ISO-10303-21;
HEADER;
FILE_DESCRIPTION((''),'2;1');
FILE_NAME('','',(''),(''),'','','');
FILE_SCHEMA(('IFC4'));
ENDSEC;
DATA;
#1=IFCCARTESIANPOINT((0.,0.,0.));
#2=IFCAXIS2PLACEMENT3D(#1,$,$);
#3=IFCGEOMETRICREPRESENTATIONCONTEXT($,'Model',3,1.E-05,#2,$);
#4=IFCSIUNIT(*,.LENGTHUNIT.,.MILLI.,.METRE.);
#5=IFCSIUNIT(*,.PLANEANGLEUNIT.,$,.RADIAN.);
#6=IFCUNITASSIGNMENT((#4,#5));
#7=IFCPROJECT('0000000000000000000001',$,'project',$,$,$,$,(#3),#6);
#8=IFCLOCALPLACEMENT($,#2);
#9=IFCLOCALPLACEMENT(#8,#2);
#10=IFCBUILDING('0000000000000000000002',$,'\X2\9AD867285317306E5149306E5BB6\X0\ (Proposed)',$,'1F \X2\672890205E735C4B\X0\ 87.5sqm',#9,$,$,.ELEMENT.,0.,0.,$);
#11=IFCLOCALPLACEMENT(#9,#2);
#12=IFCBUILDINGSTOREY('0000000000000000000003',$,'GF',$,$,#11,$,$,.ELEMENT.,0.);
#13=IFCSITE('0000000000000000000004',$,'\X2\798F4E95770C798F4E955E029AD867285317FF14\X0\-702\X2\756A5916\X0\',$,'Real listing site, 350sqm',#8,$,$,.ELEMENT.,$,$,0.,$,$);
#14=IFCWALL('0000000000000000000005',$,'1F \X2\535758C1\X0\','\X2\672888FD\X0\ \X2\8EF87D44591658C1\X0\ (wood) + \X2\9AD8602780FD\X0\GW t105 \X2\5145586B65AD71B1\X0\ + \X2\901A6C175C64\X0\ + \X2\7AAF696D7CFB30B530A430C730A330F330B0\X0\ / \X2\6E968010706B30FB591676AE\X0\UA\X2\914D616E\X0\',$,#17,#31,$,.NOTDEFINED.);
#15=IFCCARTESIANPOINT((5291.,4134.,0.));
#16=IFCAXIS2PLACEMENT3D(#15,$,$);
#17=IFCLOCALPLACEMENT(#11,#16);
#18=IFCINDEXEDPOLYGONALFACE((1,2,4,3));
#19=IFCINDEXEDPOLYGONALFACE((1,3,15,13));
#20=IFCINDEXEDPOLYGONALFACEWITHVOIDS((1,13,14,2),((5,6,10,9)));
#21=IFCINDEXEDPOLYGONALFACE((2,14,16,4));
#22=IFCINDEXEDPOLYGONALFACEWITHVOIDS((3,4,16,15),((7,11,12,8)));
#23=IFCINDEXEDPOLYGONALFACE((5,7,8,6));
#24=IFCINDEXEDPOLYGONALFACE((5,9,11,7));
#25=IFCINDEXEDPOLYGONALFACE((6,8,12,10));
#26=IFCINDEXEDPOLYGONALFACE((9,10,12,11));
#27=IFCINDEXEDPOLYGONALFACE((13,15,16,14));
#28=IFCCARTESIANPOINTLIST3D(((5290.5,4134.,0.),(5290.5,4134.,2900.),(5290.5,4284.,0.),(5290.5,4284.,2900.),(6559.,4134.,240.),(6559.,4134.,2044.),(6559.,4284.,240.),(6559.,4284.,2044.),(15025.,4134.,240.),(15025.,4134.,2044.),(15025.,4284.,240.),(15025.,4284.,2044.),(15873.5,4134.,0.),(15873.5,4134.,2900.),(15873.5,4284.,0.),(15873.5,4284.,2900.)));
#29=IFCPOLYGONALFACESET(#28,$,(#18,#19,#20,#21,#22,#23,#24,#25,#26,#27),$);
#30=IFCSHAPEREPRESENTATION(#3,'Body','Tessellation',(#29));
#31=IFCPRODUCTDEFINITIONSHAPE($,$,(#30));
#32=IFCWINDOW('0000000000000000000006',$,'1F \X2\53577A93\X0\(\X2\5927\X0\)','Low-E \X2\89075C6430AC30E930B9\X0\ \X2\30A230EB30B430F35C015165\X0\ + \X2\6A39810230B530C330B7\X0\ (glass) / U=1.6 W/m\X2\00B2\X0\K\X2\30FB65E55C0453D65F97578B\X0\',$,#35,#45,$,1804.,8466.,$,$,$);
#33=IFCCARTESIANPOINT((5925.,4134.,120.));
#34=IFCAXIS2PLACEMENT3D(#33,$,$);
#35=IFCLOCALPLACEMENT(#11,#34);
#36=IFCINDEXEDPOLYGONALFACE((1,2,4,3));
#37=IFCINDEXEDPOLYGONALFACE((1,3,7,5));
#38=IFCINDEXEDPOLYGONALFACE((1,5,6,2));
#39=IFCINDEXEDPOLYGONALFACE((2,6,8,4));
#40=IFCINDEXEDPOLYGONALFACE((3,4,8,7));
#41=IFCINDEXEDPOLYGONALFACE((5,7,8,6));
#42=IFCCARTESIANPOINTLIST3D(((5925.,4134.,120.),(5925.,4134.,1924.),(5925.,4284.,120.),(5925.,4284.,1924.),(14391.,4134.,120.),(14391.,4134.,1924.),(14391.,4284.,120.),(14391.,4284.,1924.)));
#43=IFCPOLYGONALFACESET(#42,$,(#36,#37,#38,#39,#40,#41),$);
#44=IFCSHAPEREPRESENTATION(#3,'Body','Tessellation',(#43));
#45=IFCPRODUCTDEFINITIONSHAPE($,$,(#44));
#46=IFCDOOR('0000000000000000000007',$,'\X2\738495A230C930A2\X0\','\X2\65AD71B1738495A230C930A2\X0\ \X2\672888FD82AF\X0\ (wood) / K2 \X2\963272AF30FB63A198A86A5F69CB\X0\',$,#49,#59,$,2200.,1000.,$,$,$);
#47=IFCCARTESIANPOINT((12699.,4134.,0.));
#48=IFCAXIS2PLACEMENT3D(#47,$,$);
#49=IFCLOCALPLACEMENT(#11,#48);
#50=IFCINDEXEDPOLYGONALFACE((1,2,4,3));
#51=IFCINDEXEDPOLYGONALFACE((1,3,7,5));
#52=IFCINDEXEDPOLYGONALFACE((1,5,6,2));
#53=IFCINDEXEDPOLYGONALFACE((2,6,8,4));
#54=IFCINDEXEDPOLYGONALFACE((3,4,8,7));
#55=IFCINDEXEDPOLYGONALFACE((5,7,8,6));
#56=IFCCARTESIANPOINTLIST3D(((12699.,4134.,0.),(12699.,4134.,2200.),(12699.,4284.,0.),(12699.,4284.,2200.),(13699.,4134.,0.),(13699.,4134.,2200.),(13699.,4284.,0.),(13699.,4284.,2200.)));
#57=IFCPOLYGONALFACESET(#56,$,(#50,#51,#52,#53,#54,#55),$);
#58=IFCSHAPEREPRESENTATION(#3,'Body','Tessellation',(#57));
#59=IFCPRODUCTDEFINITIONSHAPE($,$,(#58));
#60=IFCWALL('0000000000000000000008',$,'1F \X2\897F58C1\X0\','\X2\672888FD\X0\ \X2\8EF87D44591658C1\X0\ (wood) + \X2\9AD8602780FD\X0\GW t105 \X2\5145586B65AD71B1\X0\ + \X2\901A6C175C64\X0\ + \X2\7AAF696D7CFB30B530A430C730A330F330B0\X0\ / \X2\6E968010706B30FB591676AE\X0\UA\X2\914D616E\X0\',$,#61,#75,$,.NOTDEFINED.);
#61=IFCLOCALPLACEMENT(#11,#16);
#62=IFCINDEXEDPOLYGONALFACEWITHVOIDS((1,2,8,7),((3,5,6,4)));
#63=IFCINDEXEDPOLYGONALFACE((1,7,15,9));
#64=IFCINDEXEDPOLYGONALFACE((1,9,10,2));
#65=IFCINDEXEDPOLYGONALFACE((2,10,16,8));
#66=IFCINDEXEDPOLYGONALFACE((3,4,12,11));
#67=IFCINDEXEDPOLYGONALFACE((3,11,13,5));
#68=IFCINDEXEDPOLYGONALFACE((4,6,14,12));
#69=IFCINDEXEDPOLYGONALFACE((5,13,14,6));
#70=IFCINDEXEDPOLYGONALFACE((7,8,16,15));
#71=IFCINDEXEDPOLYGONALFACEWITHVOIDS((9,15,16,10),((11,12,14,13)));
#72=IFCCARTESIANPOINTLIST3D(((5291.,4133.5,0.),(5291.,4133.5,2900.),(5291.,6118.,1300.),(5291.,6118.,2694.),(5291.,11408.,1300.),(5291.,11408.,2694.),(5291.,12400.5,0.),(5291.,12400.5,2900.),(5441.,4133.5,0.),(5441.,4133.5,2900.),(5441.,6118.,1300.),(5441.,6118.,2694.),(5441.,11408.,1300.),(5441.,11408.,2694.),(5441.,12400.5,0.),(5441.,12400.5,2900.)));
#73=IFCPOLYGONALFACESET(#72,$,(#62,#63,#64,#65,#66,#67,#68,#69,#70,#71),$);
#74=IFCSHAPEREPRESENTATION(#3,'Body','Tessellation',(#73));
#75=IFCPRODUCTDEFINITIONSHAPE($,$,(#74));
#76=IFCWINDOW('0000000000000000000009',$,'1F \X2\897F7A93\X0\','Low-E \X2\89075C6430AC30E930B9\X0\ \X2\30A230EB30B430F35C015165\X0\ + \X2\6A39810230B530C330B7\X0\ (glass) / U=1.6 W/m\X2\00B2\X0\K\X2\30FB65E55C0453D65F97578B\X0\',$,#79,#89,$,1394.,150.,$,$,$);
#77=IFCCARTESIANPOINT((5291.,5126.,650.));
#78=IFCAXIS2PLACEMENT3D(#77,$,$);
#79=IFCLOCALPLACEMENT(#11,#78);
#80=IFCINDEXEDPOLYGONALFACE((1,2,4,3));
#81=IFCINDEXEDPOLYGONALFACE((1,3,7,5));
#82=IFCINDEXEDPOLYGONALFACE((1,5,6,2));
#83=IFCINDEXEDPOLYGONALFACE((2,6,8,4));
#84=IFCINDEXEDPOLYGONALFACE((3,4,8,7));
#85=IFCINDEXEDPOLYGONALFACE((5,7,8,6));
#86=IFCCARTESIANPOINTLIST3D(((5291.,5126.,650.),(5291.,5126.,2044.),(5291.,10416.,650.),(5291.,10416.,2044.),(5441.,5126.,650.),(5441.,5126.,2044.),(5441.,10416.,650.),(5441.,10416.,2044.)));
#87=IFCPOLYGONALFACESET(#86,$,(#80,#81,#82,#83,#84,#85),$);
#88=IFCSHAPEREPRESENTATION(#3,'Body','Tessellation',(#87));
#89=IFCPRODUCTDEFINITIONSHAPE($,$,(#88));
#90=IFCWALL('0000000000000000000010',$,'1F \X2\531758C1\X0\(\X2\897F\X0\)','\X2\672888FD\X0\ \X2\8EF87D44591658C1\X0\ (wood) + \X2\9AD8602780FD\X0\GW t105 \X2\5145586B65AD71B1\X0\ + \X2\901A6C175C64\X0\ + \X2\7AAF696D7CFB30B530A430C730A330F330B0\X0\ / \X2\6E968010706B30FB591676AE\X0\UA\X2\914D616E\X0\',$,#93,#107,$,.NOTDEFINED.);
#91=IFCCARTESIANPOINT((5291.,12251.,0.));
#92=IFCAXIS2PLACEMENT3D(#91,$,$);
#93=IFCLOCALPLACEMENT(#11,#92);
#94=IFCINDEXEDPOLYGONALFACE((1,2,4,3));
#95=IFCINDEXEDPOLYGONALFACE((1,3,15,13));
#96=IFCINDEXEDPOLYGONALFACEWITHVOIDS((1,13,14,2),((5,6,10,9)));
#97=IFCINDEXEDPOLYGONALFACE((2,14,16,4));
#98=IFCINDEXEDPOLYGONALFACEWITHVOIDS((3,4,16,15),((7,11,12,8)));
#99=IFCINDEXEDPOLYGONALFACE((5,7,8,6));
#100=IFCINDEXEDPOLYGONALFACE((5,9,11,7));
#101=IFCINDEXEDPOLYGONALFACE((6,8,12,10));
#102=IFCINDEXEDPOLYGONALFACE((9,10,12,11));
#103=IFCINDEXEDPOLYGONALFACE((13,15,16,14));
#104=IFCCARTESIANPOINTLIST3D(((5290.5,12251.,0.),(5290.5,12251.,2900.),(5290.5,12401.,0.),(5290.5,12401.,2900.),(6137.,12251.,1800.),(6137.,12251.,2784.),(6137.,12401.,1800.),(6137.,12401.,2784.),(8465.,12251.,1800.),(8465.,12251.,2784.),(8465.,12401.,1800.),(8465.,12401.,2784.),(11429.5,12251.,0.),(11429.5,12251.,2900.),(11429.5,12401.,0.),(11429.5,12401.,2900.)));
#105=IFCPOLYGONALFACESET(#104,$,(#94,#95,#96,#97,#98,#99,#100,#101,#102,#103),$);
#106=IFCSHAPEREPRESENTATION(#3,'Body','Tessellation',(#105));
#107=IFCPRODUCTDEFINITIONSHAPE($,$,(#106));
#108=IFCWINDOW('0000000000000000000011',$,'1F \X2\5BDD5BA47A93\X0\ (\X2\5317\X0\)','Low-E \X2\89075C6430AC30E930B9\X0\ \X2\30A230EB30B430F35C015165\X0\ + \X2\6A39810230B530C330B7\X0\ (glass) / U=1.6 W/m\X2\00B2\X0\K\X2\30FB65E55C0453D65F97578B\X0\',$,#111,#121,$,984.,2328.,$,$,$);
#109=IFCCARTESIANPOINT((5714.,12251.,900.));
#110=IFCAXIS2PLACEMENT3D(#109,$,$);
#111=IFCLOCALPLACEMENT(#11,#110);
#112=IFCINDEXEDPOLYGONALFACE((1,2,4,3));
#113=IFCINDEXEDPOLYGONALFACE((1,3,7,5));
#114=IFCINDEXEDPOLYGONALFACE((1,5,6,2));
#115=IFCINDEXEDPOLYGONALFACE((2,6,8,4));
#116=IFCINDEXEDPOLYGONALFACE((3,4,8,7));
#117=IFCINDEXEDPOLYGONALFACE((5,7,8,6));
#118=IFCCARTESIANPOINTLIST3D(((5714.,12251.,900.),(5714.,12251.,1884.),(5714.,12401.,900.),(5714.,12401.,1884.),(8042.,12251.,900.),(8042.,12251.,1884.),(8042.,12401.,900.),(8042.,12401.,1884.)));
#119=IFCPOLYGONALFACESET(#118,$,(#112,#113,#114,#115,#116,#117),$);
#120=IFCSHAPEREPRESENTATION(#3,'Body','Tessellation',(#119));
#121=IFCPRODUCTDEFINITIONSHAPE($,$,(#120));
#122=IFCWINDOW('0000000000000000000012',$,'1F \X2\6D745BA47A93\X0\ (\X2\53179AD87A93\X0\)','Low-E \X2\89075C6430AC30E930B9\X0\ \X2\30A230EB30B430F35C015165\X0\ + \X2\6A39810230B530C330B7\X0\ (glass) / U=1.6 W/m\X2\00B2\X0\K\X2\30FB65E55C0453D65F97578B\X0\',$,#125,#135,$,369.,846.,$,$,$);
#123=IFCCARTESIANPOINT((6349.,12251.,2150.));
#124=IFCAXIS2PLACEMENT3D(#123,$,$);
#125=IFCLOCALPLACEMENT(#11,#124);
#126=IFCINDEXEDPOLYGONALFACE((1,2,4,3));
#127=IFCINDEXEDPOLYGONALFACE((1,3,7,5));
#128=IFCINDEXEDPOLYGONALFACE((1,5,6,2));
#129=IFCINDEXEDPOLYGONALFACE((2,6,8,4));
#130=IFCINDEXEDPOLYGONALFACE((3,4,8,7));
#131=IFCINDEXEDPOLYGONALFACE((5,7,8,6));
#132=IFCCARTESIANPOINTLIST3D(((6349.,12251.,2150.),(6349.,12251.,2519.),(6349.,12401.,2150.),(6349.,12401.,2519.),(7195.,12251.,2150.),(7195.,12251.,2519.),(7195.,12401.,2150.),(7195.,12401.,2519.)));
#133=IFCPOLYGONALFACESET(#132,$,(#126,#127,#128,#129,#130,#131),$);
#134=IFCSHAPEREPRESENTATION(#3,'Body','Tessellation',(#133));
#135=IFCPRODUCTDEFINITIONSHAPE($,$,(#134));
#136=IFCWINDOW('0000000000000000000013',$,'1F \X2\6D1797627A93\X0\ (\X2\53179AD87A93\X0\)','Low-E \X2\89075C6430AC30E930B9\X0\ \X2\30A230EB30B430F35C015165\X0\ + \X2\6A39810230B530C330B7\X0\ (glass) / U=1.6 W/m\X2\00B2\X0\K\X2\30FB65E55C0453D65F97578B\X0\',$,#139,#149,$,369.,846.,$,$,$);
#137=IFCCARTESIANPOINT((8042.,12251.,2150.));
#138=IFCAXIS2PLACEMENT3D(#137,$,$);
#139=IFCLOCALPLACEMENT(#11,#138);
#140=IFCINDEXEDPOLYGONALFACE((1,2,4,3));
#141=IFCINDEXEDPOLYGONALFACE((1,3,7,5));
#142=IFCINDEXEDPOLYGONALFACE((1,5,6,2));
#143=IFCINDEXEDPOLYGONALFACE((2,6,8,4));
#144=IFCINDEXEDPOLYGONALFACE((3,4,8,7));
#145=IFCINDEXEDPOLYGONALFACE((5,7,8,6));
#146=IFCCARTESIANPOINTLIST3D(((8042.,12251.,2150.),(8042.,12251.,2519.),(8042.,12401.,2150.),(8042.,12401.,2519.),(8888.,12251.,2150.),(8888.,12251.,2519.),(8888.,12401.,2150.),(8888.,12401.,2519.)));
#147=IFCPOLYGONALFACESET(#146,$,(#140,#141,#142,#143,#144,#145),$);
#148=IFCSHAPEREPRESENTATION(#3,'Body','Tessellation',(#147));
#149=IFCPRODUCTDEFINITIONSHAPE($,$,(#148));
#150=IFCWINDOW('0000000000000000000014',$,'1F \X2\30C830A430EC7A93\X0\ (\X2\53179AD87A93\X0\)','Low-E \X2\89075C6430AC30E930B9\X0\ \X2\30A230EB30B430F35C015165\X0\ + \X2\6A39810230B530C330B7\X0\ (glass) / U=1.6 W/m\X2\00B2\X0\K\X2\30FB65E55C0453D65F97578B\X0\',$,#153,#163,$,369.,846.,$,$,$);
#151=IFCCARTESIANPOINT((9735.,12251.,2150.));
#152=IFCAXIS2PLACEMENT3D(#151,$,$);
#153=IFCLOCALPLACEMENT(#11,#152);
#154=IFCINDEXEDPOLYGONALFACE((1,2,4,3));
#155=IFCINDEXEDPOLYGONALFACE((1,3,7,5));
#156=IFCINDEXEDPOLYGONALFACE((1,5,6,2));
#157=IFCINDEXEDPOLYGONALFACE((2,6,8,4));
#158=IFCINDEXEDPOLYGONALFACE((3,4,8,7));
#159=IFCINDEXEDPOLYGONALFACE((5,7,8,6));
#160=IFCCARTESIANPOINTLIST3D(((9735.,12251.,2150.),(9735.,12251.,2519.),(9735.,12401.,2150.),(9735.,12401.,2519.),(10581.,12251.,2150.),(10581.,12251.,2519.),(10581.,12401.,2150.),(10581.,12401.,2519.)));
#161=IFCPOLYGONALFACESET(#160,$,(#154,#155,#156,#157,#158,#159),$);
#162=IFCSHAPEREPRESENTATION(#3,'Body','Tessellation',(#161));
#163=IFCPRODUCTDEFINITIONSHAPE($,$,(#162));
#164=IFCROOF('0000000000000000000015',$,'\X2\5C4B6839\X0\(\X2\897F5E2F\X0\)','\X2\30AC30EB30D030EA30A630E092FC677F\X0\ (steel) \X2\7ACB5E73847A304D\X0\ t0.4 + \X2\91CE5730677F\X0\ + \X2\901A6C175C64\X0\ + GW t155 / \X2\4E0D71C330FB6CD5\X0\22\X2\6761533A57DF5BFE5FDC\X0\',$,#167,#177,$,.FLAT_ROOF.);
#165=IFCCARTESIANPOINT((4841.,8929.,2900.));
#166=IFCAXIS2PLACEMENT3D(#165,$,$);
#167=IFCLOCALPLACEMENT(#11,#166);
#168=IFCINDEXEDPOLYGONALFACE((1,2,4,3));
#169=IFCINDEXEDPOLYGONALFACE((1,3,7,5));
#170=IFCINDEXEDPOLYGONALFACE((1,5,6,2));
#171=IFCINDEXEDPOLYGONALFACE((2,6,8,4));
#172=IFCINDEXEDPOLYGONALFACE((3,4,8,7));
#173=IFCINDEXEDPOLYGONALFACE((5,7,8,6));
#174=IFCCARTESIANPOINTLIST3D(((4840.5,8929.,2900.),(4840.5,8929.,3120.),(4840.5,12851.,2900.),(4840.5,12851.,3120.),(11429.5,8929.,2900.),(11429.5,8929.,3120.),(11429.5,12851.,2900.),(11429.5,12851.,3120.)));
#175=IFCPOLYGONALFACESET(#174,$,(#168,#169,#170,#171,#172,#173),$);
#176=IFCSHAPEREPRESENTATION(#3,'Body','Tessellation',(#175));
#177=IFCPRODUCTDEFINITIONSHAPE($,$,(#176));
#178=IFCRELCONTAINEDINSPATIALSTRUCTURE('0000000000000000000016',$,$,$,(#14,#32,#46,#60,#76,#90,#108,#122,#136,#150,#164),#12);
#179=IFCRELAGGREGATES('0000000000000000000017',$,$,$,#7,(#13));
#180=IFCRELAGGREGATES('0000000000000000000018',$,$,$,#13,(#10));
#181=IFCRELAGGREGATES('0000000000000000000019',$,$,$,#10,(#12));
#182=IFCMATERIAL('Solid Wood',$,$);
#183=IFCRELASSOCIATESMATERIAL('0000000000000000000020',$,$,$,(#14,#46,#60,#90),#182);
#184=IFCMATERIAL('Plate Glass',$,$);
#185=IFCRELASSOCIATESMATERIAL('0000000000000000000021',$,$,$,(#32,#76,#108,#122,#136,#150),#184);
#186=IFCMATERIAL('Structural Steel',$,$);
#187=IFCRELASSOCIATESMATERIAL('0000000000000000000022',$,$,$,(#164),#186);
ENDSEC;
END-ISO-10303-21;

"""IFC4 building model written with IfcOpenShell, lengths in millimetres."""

from ifc_helpers import new_model, si_unit, frame, frame_2d, origin, place, context, project, spatial, rectangle, extrude, material, element, fill, save


model = new_model("IFC4")

# Units and contexts
model_context = context("Model", 3, precision=1e-05, world=origin())
ifc_project = project(units=[si_unit("LENGTHUNIT", "METRE", prefix="MILLI"), si_unit("PLANEANGLEUNIT", "RADIAN")], contexts=[model_context])

# Site, building, storey
site_placement = place(None, origin())
site = spatial("IfcSite", under=ifc_project, at=site_placement, Name="福井県福井市高木北４-702番外", ObjectType="Real listing site, 350sqm", CompositionType="ELEMENT", RefElevation=0.0)
building_placement = place(site_placement, origin())
building = spatial("IfcBuilding", under=site, at=building_placement, Name="高木北の光の家 (Proposed)", ObjectType="1F 木造平屋 87.5sqm", CompositionType="ELEMENT", ElevationOfRefHeight=0.0, ElevationOfTerrain=0.0)
storey_placement = place(building_placement, origin())
storey = spatial("IfcBuildingStorey", under=building, at=storey_placement, Name="GF", CompositionType="ELEMENT", Elevation=0.0)

# Shared definitions
ifc_material_1 = material(Name="Solid Wood")

# Wall, openings, window, door
wall_1_placement = place(storey_placement, frame((5291.0, 4134.0, 0.0)))
wall_1 = element("IfcWall", 1, at=wall_1_placement, inside=storey, material=ifc_material_1, Name="1F 南壁", Description="木製 軸組外壁 (wood) + 高性能GW t105 充填断熱 + 通気層 + 窯業系サイディング / 準耐火・外皮UA配慮", PredefinedType="NOTDEFINED", context=model_context, shape_type="SweptSolid", body=[
    extrude(rectangle(XDim=10583.0, YDim=150.0, at=frame_2d((5291.0, 75.0))), frame((5291.0, 4134.0, 0.0)), (0.0, 0.0, 1.0), 2900.0),
])
opening_1_placement = place(storey_placement, frame((5925.0, 4134.0, 120.0)))
opening_1 = element("IfcOpeningElement", 2, at=opening_1_placement, cuts=wall_1, PredefinedType="NOTDEFINED", context=model_context, shape_type="SweptSolid", body=[
    extrude(rectangle(XDim=8466.0, YDim=150.0, at=frame_2d((4233.0, 75.0))), frame((5925.0, 4134.0, 120.0)), (0.0, 0.0, 1.0), 1804.0),
])
opening_2_placement = place(storey_placement, frame((12699.0, 4134.0, 0.0)))
opening_2 = element("IfcOpeningElement", 3, at=opening_2_placement, cuts=wall_1, PredefinedType="NOTDEFINED", context=model_context, shape_type="SweptSolid", body=[
    extrude(rectangle(XDim=1000.0, YDim=150.0, at=frame_2d((500.0, 75.0))), frame((12699.0, 4134.0, 0.0)), (0.0, 0.0, 1.0), 2200.0),
])
ifc_material_2 = material(Name="Plate Glass")
window_1_placement = place(storey_placement, frame((5925.0, 4134.0, 120.0)))
window_1 = element("IfcWindow", 4, at=window_1_placement, inside=storey, material=ifc_material_2, Name="1F 南窓(大)", Description="Low-E 複層ガラス アルゴン封入 + 樹脂サッシ (glass) / U=1.6 W/m²K・日射取得型", OverallHeight=1804.0, OverallWidth=8466.0, context=model_context, shape_type="SweptSolid", body=[
    extrude(rectangle(XDim=8466.0, YDim=150.0, at=frame_2d((4233.0, 75.0))), frame((5925.0, 4134.0, 120.0)), (0.0, 0.0, 1.0), 1804.0),
])
fill(opening_1, window_1)
door_1_placement = place(storey_placement, frame((12699.0, 4134.0, 0.0)))
door_1 = element("IfcDoor", 5, at=door_1_placement, inside=storey, material=ifc_material_1, Name="玄関ドア", Description="断熱玄関ドア 木製芯 (wood) / K2 防犯・採風機構", OverallHeight=2200.0, OverallWidth=1000.0, context=model_context, shape_type="SweptSolid", body=[
    extrude(rectangle(XDim=1000.0, YDim=150.0, at=frame_2d((500.0, 75.0))), frame((12699.0, 4134.0, 0.0)), (0.0, 0.0, 1.0), 2200.0),
])
fill(opening_2, door_1)

# Wall, opening, window
wall_2_placement = place(storey_placement, frame((5291.0, 4134.0, 0.0)))
wall_2 = element("IfcWall", 6, at=wall_2_placement, inside=storey, material=ifc_material_1, Name="1F 西壁", Description="木製 軸組外壁 (wood) + 高性能GW t105 充填断熱 + 通気層 + 窯業系サイディング / 準耐火・外皮UA配慮", PredefinedType="NOTDEFINED", context=model_context, shape_type="SweptSolid", body=[
    extrude(rectangle(XDim=150.0, YDim=8267.0, at=frame_2d((75.0, 4133.0))), frame((5291.0, 4134.0, 0.0)), (0.0, 0.0, 1.0), 2900.0),
])
opening_3_placement = place(storey_placement, frame((5291.0, 5126.0, 650.0)))
opening_3 = element("IfcOpeningElement", 7, at=opening_3_placement, cuts=wall_2, PredefinedType="NOTDEFINED", context=model_context, shape_type="SweptSolid", body=[
    extrude(rectangle(XDim=150.0, YDim=5290.0, at=frame_2d((75.0, 2645.0))), frame((5291.0, 5126.0, 650.0)), (0.0, 0.0, 1.0), 1394.0),
])
window_2_placement = place(storey_placement, frame((5291.0, 5126.0, 650.0)))
window_2 = element("IfcWindow", 8, at=window_2_placement, inside=storey, material=ifc_material_2, Name="1F 西窓", Description="Low-E 複層ガラス アルゴン封入 + 樹脂サッシ (glass) / U=1.6 W/m²K・日射取得型", OverallHeight=1394.0, OverallWidth=150.0, context=model_context, shape_type="SweptSolid", body=[
    extrude(rectangle(XDim=150.0, YDim=5290.0, at=frame_2d((75.0, 2645.0))), frame((5291.0, 5126.0, 650.0)), (0.0, 0.0, 1.0), 1394.0),
])
fill(opening_3, window_2)

# Wall, openings, windows
wall_3_placement = place(storey_placement, frame((5291.0, 12251.0, 0.0)))
wall_3 = element("IfcWall", 9, at=wall_3_placement, inside=storey, material=ifc_material_1, Name="1F 北壁(西)", Description="木製 軸組外壁 (wood) + 高性能GW t105 充填断熱 + 通気層 + 窯業系サイディング / 準耐火・外皮UA配慮", PredefinedType="NOTDEFINED", context=model_context, shape_type="SweptSolid", body=[
    extrude(rectangle(XDim=6139.0, YDim=150.0, at=frame_2d((3069.0, 75.0))), frame((5291.0, 12251.0, 0.0)), (0.0, 0.0, 1.0), 2900.0),
])
opening_4_placement = place(storey_placement, frame((5714.0, 12251.0, 900.0)))
opening_4 = element("IfcOpeningElement", 10, at=opening_4_placement, cuts=wall_3, PredefinedType="NOTDEFINED", context=model_context, shape_type="SweptSolid", body=[
    extrude(rectangle(XDim=2328.0, YDim=150.0, at=frame_2d((1164.0, 75.0))), frame((5714.0, 12251.0, 900.0)), (0.0, 0.0, 1.0), 984.0),
])
opening_5_placement = place(storey_placement, frame((6349.0, 12251.0, 2150.0)))
opening_5 = element("IfcOpeningElement", 11, at=opening_5_placement, cuts=wall_3, PredefinedType="NOTDEFINED", context=model_context, shape_type="SweptSolid", body=[
    extrude(rectangle(XDim=846.0, YDim=150.0, at=frame_2d((423.0, 75.0))), frame((6349.0, 12251.0, 2150.0)), (0.0, 0.0, 1.0), 369.0),
])
opening_6_placement = place(storey_placement, frame((8042.0, 12251.0, 2150.0)))
opening_6 = element("IfcOpeningElement", 12, at=opening_6_placement, cuts=wall_3, PredefinedType="NOTDEFINED", context=model_context, shape_type="SweptSolid", body=[
    extrude(rectangle(XDim=846.0, YDim=150.0, at=frame_2d((423.0, 75.0))), frame((8042.0, 12251.0, 2150.0)), (0.0, 0.0, 1.0), 369.0),
])
opening_7_placement = place(storey_placement, frame((9735.0, 12251.0, 2150.0)))
opening_7 = element("IfcOpeningElement", 13, at=opening_7_placement, cuts=wall_3, PredefinedType="NOTDEFINED", context=model_context, shape_type="SweptSolid", body=[
    extrude(rectangle(XDim=846.0, YDim=150.0, at=frame_2d((423.0, 75.0))), frame((9735.0, 12251.0, 2150.0)), (0.0, 0.0, 1.0), 369.0),
])
window_3_placement = place(storey_placement, frame((5714.0, 12251.0, 900.0)))
window_3 = element("IfcWindow", 14, at=window_3_placement, inside=storey, material=ifc_material_2, Name="1F 寝室窓 (北)", Description="Low-E 複層ガラス アルゴン封入 + 樹脂サッシ (glass) / U=1.6 W/m²K・日射取得型", OverallHeight=984.0, OverallWidth=2328.0, context=model_context, shape_type="SweptSolid", body=[
    extrude(rectangle(XDim=2328.0, YDim=150.0, at=frame_2d((1164.0, 75.0))), frame((5714.0, 12251.0, 900.0)), (0.0, 0.0, 1.0), 984.0),
])
fill(opening_4, window_3)
window_4_placement = place(storey_placement, frame((6349.0, 12251.0, 2150.0)))
window_4 = element("IfcWindow", 15, at=window_4_placement, inside=storey, material=ifc_material_2, Name="1F 浴室窓 (北高窓)", Description="Low-E 複層ガラス アルゴン封入 + 樹脂サッシ (glass) / U=1.6 W/m²K・日射取得型", OverallHeight=369.0, OverallWidth=846.0, context=model_context, shape_type="SweptSolid", body=[
    extrude(rectangle(XDim=846.0, YDim=150.0, at=frame_2d((423.0, 75.0))), frame((6349.0, 12251.0, 2150.0)), (0.0, 0.0, 1.0), 369.0),
])
fill(opening_5, window_4)
window_5_placement = place(storey_placement, frame((8042.0, 12251.0, 2150.0)))
window_5 = element("IfcWindow", 16, at=window_5_placement, inside=storey, material=ifc_material_2, Name="1F 洗面窓 (北高窓)", Description="Low-E 複層ガラス アルゴン封入 + 樹脂サッシ (glass) / U=1.6 W/m²K・日射取得型", OverallHeight=369.0, OverallWidth=846.0, context=model_context, shape_type="SweptSolid", body=[
    extrude(rectangle(XDim=846.0, YDim=150.0, at=frame_2d((423.0, 75.0))), frame((8042.0, 12251.0, 2150.0)), (0.0, 0.0, 1.0), 369.0),
])
fill(opening_6, window_5)
window_6_placement = place(storey_placement, frame((9735.0, 12251.0, 2150.0)))
window_6 = element("IfcWindow", 17, at=window_6_placement, inside=storey, material=ifc_material_2, Name="1F トイレ窓 (北高窓)", Description="Low-E 複層ガラス アルゴン封入 + 樹脂サッシ (glass) / U=1.6 W/m²K・日射取得型", OverallHeight=369.0, OverallWidth=846.0, context=model_context, shape_type="SweptSolid", body=[
    extrude(rectangle(XDim=846.0, YDim=150.0, at=frame_2d((423.0, 75.0))), frame((9735.0, 12251.0, 2150.0)), (0.0, 0.0, 1.0), 369.0),
])
fill(opening_7, window_6)

# Roof
ifc_material_3 = material(Name="Structural Steel")
roof_1_placement = place(storey_placement, frame((4841.0, 8929.0, 2900.0)))
element("IfcRoof", 18, at=roof_1_placement, inside=storey, material=ifc_material_3, Name="屋根(西帯)", Description="ガルバリウム鋼板 (steel) 立平葺き t0.4 + 野地板 + 通気層 + GW t155 / 不燃・法22条区域対応", PredefinedType="FLAT_ROOF", context=model_context, shape_type="SweptSolid", body=[
    extrude(rectangle(XDim=6589.0, YDim=3922.0, at=frame_2d((3294.0, 1961.0))), frame((4841.0, 8929.0, 2900.0)), (0.0, 0.0, 1.0), 220.0),
])

save(model, "model.ifc")
